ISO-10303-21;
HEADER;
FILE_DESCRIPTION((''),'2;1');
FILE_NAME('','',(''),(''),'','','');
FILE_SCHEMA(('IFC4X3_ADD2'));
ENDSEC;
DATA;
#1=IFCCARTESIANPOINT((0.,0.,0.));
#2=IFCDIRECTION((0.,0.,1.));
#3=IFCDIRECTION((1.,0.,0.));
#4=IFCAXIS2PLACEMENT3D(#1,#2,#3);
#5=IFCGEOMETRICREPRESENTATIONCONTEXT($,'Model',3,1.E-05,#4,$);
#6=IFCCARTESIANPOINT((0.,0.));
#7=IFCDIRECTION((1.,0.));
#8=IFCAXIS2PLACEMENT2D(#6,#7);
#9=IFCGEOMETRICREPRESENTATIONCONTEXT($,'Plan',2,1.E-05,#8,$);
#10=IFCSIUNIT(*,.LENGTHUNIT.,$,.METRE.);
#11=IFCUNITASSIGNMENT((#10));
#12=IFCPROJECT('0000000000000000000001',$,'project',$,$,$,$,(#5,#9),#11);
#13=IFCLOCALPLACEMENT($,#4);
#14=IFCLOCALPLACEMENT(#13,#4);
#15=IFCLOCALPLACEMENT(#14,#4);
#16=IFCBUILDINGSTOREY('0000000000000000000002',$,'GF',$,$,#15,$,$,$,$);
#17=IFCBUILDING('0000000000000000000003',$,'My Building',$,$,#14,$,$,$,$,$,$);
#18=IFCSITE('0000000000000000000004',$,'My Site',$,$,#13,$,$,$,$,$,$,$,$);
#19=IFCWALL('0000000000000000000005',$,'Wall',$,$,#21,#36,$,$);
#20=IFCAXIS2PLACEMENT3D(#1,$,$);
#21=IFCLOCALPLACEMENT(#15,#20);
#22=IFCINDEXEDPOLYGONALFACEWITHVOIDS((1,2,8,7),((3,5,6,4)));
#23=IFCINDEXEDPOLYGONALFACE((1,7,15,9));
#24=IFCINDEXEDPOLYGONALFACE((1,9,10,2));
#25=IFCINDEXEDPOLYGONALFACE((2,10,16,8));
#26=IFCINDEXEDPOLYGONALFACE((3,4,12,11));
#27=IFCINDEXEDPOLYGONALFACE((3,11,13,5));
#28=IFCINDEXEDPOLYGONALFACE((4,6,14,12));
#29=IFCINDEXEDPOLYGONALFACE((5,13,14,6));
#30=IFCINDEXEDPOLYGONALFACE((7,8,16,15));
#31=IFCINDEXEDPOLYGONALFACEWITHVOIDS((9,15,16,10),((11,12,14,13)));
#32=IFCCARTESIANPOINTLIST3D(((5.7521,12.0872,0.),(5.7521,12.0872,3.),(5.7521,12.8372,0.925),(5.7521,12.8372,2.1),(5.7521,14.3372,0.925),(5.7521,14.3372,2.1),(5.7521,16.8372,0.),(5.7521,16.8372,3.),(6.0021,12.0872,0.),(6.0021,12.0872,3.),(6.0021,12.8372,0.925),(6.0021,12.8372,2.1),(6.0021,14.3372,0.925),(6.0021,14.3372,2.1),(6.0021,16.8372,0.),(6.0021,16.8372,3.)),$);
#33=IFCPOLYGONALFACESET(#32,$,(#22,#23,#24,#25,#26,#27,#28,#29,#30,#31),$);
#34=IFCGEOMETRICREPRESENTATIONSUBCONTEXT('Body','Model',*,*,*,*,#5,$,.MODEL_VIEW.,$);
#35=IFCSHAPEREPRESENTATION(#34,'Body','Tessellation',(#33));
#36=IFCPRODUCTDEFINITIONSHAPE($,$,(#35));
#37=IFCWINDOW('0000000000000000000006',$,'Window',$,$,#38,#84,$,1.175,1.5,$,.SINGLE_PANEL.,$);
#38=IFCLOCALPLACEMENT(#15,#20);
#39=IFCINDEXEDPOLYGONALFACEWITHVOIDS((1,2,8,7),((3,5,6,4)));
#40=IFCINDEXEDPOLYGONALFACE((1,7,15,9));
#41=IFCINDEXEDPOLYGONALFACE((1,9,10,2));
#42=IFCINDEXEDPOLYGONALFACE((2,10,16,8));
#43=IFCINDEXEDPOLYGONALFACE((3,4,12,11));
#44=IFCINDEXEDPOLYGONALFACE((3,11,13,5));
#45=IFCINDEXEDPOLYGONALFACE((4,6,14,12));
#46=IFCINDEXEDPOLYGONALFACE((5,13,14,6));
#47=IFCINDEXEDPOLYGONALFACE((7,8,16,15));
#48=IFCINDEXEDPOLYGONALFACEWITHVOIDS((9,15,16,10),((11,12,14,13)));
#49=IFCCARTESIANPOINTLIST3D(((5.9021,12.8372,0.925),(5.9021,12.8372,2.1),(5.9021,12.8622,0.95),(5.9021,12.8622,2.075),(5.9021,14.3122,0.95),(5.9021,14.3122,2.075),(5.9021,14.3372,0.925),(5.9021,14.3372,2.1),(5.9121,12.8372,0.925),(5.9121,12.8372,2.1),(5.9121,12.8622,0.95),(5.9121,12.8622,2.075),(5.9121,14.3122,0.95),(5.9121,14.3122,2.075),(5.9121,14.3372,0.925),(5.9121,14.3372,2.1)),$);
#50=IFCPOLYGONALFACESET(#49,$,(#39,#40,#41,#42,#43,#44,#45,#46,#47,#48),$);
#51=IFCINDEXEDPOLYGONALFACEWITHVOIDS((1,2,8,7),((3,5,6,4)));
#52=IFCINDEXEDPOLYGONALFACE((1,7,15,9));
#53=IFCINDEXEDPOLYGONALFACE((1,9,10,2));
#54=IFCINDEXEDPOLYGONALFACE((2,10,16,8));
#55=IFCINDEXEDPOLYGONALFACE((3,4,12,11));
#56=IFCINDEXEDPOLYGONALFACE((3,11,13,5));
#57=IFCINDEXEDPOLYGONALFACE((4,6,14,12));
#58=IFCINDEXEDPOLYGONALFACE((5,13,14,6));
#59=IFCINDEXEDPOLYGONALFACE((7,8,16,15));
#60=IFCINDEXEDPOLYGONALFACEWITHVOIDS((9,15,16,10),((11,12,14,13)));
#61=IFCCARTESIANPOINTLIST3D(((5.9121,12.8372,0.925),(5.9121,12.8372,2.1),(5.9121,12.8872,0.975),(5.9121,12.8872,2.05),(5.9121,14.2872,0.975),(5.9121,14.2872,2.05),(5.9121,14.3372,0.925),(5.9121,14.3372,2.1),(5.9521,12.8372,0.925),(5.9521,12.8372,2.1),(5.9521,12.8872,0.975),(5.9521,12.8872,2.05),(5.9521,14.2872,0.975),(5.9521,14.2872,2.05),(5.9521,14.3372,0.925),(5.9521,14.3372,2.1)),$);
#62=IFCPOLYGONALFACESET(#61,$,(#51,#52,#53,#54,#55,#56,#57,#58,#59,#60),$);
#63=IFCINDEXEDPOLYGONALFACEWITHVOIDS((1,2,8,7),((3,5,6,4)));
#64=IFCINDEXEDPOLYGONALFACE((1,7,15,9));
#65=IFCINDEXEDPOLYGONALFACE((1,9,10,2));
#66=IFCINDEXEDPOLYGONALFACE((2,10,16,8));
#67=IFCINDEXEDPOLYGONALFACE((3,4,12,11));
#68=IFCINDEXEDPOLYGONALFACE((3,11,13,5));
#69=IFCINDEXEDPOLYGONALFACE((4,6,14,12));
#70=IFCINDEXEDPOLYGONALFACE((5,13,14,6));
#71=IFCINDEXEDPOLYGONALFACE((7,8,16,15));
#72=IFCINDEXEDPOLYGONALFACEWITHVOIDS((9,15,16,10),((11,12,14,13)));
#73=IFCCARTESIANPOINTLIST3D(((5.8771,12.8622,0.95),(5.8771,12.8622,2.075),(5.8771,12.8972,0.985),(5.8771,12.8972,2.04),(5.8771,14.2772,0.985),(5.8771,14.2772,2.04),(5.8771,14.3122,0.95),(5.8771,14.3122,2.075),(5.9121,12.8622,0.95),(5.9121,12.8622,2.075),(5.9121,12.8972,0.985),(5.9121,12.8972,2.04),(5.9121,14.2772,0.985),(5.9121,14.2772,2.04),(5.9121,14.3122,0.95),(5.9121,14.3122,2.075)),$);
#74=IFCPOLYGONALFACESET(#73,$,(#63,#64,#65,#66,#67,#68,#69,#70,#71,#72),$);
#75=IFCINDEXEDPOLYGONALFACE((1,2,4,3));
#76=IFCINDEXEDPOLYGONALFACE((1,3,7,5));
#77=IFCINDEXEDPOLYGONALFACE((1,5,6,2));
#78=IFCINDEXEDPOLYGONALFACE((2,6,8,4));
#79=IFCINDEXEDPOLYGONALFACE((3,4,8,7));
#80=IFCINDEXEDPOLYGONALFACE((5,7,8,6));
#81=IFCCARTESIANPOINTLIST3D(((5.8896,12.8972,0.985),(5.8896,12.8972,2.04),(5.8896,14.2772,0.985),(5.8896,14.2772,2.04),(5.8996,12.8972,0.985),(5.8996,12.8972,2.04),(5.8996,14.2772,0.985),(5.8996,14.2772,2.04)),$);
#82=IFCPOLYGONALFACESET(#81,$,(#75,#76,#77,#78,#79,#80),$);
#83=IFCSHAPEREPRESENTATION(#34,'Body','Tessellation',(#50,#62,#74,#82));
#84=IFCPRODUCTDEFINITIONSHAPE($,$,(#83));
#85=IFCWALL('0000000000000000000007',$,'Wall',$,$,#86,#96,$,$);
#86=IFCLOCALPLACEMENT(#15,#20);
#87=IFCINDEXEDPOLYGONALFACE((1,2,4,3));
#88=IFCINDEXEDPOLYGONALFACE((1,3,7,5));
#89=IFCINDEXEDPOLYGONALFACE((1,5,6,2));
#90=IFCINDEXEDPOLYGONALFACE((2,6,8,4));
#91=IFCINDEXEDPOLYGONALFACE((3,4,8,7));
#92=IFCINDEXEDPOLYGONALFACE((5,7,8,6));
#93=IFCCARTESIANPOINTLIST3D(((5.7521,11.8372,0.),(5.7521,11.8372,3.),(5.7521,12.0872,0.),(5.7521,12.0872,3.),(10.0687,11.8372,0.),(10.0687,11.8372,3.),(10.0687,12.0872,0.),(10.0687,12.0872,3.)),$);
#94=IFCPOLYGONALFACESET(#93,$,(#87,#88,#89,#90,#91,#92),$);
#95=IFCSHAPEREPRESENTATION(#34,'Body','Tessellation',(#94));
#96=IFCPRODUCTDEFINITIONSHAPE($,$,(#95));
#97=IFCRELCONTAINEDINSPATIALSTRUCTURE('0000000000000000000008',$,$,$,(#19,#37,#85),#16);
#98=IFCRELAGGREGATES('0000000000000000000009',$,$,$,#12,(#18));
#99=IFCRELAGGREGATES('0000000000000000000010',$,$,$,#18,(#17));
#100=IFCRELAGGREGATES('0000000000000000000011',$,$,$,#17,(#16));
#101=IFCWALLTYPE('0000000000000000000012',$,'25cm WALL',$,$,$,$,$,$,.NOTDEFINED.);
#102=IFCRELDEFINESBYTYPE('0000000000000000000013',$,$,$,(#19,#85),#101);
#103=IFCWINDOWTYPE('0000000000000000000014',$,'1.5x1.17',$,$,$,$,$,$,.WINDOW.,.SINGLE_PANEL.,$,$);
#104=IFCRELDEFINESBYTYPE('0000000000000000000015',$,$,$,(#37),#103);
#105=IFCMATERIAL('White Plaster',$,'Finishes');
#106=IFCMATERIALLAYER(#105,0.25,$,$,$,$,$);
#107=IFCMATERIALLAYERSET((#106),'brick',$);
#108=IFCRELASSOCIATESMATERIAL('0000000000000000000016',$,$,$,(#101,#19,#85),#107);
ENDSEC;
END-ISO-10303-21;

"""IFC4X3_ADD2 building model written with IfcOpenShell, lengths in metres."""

from ifc_helpers import new_model, entity, si_unit, frame, origin_with_axes, origin_2d_with_axis, place, context, subcontext, project, spatial, line, indexed_curve, outline, extrude, shape, source, transform, mapped, material, layer, layer_set, layer_usage, type_object, type_shapes, element, fill, save


model = new_model("IFC4X3_ADD2")

# Units and contexts
model_context = context("Model", 3, precision=1e-05, world=origin_with_axes())
plan_context = context("Plan", 2, precision=1e-05, world=origin_2d_with_axis())
body_context_1 = subcontext(model_context, "Body", "Model", "MODEL_VIEW")
body_context_2 = subcontext(plan_context, "Body", "Plan", "PLAN_VIEW")
ifc_project = project(units=[si_unit("LENGTHUNIT", "METRE")], contexts=[model_context, plan_context])

# Site, building, storey
site_placement = place(None, origin_with_axes())
site = spatial("IfcSite", under=ifc_project, at=site_placement, Name="My Site")
building_placement = place(site_placement, origin_with_axes())
building = spatial("IfcBuilding", under=site, at=building_placement, Name="My Building")
storey_placement = place(building_placement, origin_with_axes())
storey = spatial("IfcBuildingStorey", under=building, at=storey_placement, Name="GF")

# Shared definitions
ifc_material_1 = material(Name="White Plaster", Category="Finishes")

# Shared definitions
ifc_layer_1 = layer(ifc_material_1, 0.25)
ifc_layer_set_1 = layer_set([ifc_layer_1], Name="brick")
wall_type_1 = type_object("IfcWallType", Name="25cm WALL", PredefinedType="NOTDEFINED", material=ifc_layer_set_1)
shared_shape_1 = source(origin_with_axes(), body_context_1, "Body", "SweptSolid", [
    extrude(outline(indexed_curve([(0.0, 0.0), (1.5, 0.0), (1.5, 1.175), (0.0, 1.175)], segments=[line(1, 2, 3, 4, 1)])), frame((0.0, -0.6, 0.0), z_axis=(0.0, -1.0, 0.0), x_axis=(1.0, 0.0, 0.0)), (0.0, 0.0, -1.0), 1.2),
])
window_type_1 = type_object("IfcWindowType", Name="1.5x1.17", PartitioningType="SINGLE_PANEL", PredefinedType="WINDOW")
shared_shape_2 = source(origin_with_axes(), body_context_1, "Body", "SweptSolid", [
    extrude(outline(indexed_curve([(0.0, 0.0), (1.5, 0.0), (1.5, 1.175), (0.0, 1.175)], segments=[line(1, 2, 3, 4, 1)]), holes=[indexed_curve([(0.025, 0.025), (1.475, 0.025), (1.475, 1.15), (0.025, 1.15)], segments=[line(1, 2, 3, 4, 1)])]), frame((0.0, 0.09, 0.0), z_axis=(0.0, -1.0, 0.0), x_axis=(1.0, 0.0, 0.0)), (0.0, 0.0, -1.0), 0.01),
    extrude(outline(indexed_curve([(0.0, 0.0), (1.5, 0.0), (1.5, 1.175), (0.0, 1.175)], segments=[line(1, 2, 3, 4, 1)]), holes=[indexed_curve([(0.05, 0.05), (1.45, 0.05), (1.45, 1.125), (0.05, 1.125)], segments=[line(1, 2, 3, 4, 1)])]), frame((0.0, 0.05, 0.0), z_axis=(0.0, -1.0, 0.0), x_axis=(1.0, 0.0, 0.0)), (0.0, 0.0, -1.0), 0.04),
    extrude(outline(indexed_curve([(0.0, 0.0), (1.45, 0.0), (1.45, 1.125), (0.0, 1.125)], segments=[line(1, 2, 3, 4, 1)]), holes=[indexed_curve([(0.035, 0.035), (1.415, 0.035), (1.415, 1.09), (0.035, 1.09)], segments=[line(1, 2, 3, 4, 1)])]), frame((0.025, 0.09, 0.025), z_axis=(0.0, -1.0, 0.0), x_axis=(1.0, 0.0, 0.0)), (0.0, 0.0, -1.0), 0.035),
    extrude(outline(indexed_curve([(0.035, 0.035), (1.415, 0.035), (1.415, 1.09), (0.035, 1.09)], segments=[line(1, 2, 3, 4, 1)])), frame((0.025, 0.1025, 0.025), z_axis=(0.0, -1.0, 0.0), x_axis=(1.0, 0.0, 0.0)), (0.0, 0.0, -1.0), 0.01),
])
shared_shape_3 = source(origin_with_axes(), body_context_2, "Body", "Curve2D", [
    entity("IfcIndexedPolyCurve", entity("IfcCartesianPointList2D", [[0.05, 0.05], [1.45, 0.05]])),
    entity("IfcIndexedPolyCurve", entity("IfcCartesianPointList2D", [[0.0, 0.1], [0.025, 0.1], [0.025, 0.09], [0.05, 0.09], [0.05, 0.05], [0.0, 0.05]]), [entity("IfcLineIndex", [1, 2, 3, 4, 5, 6, 1])]),
    entity("IfcIndexedPolyCurve", entity("IfcCartesianPointList2D", [[1.5, 0.1], [1.475, 0.1], [1.475, 0.09], [1.45, 0.09], [1.45, 0.05], [1.5, 0.05]]), [entity("IfcLineIndex", [1, 2, 3, 4, 5, 6, 1])]),
    entity("IfcIndexedPolyCurve", entity("IfcCartesianPointList2D", [[0.025, 0.09], [0.06, 0.09], [0.06, 0.125], [0.025, 0.125]]), [entity("IfcLineIndex", [1, 2, 3, 4, 1])]),
    entity("IfcIndexedPolyCurve", entity("IfcCartesianPointList2D", [[1.475, 0.09], [1.44, 0.09], [1.44, 0.125], [1.475, 0.125]]), [entity("IfcLineIndex", [1, 2, 3, 4, 1])]),
    entity("IfcIndexedPolyCurve", entity("IfcCartesianPointList2D", [[0.06, 0.09], [1.44, 0.09]])),
    entity("IfcIndexedPolyCurve", entity("IfcCartesianPointList2D", [[0.06, 0.125], [1.44, 0.125]])),
    entity("IfcIndexedPolyCurve", entity("IfcCartesianPointList2D", [[0.06, 0.1075], [1.44, 0.1075]])),
])
type_shapes(window_type_1, [shared_shape_2, shared_shape_3])

# Wall, opening, window
ifc_layer_usage_1 = layer_usage(ifc_layer_set_1, "AXIS2", "POSITIVE", 0.0)
wall_1_placement = place(storey_placement, frame((5.7521, 16.8372, 0.0), z_axis=(0.0, 0.0, 1.0), x_axis=(0.0, -1.0, 0.0)))
wall_1 = element("IfcWall", 1, at=wall_1_placement, inside=storey, type_object=wall_type_1, material=ifc_layer_usage_1, Name="Wall", context=body_context_1, shape_type="SweptSolid", body=[
    extrude(outline(indexed_curve([(0.0, 0.0), (0.0, 0.25), (4.75, 0.25), (4.75, 0.0)], segments=[line(1, 2, 3, 4, 1)])), origin_with_axes(), (0.0, 0.0, 1.0), 3.0),
])
opening_1_placement = place(wall_1_placement, frame((4.0, 0.25, 0.925), z_axis=(0.0, 0.0, 1.0), x_axis=(-1.0, 0.0, 0.0)))
opening_1 = element("IfcOpeningElement", 2, at=opening_1_placement, cuts=wall_1, PredefinedType="OPENING", context=body_context_1, shape_type="MappedRepresentation", body=[
    mapped(shared_shape_1, transform((0.0, 0.0, 0.0), x_axis=(1.0, 0.0, 0.0), y_axis=(0.0, 1.0, 0.0), z_axis=(0.0, 0.0, 1.0), scale=1.0)),
])
window_1_placement = place(opening_1_placement, frame((0.0, 0.0, 0.0), z_axis=(0.0, 0.0, 1.0), x_axis=(1.0, 0.0, 0.0)))
window_1 = element("IfcWindow", 3, at=window_1_placement, inside=storey, type_object=window_type_1, Name="Window", OverallHeight=1.175, OverallWidth=1.5, PartitioningType="SINGLE_PANEL", shapes=[
    shape(body_context_1, "Body", "MappedRepresentation", [mapped(shared_shape_2, transform((0.0, 0.0, 0.0), x_axis=(1.0, 0.0, 0.0), y_axis=(0.0, 1.0, 0.0), z_axis=(0.0, 0.0, 1.0), scale=1.0))]),
    shape(body_context_2, "Body", "MappedRepresentation", [mapped(shared_shape_3, transform((0.0, 0.0, 0.0), x_axis=(1.0, 0.0, 0.0), y_axis=(0.0, 1.0, 0.0), z_axis=(0.0, 0.0, 1.0), scale=1.0))]),
])
fill(opening_1, window_1)

# Wall
ifc_layer_usage_2 = layer_usage(ifc_layer_set_1, "AXIS2", "POSITIVE", 0.0)
wall_2_placement = place(storey_placement, frame((5.7521, 11.8372, 0.0), z_axis=(0.0, 0.0, 1.0), x_axis=(1.0, 0.0, 0.0)))
element("IfcWall", 4, at=wall_2_placement, inside=storey, type_object=wall_type_1, material=ifc_layer_usage_2, Name="Wall", context=body_context_1, shape_type="SweptSolid", body=[
    extrude(outline(indexed_curve([(0.0, 0.0), (0.0, 0.25), (4.3166, 0.25), (4.3166, 0.0)], segments=[line(1, 2, 3, 4, 1)])), origin_with_axes(), (0.0, 0.0, 1.0), 3.0),
])

save(model, "model.ifc")
